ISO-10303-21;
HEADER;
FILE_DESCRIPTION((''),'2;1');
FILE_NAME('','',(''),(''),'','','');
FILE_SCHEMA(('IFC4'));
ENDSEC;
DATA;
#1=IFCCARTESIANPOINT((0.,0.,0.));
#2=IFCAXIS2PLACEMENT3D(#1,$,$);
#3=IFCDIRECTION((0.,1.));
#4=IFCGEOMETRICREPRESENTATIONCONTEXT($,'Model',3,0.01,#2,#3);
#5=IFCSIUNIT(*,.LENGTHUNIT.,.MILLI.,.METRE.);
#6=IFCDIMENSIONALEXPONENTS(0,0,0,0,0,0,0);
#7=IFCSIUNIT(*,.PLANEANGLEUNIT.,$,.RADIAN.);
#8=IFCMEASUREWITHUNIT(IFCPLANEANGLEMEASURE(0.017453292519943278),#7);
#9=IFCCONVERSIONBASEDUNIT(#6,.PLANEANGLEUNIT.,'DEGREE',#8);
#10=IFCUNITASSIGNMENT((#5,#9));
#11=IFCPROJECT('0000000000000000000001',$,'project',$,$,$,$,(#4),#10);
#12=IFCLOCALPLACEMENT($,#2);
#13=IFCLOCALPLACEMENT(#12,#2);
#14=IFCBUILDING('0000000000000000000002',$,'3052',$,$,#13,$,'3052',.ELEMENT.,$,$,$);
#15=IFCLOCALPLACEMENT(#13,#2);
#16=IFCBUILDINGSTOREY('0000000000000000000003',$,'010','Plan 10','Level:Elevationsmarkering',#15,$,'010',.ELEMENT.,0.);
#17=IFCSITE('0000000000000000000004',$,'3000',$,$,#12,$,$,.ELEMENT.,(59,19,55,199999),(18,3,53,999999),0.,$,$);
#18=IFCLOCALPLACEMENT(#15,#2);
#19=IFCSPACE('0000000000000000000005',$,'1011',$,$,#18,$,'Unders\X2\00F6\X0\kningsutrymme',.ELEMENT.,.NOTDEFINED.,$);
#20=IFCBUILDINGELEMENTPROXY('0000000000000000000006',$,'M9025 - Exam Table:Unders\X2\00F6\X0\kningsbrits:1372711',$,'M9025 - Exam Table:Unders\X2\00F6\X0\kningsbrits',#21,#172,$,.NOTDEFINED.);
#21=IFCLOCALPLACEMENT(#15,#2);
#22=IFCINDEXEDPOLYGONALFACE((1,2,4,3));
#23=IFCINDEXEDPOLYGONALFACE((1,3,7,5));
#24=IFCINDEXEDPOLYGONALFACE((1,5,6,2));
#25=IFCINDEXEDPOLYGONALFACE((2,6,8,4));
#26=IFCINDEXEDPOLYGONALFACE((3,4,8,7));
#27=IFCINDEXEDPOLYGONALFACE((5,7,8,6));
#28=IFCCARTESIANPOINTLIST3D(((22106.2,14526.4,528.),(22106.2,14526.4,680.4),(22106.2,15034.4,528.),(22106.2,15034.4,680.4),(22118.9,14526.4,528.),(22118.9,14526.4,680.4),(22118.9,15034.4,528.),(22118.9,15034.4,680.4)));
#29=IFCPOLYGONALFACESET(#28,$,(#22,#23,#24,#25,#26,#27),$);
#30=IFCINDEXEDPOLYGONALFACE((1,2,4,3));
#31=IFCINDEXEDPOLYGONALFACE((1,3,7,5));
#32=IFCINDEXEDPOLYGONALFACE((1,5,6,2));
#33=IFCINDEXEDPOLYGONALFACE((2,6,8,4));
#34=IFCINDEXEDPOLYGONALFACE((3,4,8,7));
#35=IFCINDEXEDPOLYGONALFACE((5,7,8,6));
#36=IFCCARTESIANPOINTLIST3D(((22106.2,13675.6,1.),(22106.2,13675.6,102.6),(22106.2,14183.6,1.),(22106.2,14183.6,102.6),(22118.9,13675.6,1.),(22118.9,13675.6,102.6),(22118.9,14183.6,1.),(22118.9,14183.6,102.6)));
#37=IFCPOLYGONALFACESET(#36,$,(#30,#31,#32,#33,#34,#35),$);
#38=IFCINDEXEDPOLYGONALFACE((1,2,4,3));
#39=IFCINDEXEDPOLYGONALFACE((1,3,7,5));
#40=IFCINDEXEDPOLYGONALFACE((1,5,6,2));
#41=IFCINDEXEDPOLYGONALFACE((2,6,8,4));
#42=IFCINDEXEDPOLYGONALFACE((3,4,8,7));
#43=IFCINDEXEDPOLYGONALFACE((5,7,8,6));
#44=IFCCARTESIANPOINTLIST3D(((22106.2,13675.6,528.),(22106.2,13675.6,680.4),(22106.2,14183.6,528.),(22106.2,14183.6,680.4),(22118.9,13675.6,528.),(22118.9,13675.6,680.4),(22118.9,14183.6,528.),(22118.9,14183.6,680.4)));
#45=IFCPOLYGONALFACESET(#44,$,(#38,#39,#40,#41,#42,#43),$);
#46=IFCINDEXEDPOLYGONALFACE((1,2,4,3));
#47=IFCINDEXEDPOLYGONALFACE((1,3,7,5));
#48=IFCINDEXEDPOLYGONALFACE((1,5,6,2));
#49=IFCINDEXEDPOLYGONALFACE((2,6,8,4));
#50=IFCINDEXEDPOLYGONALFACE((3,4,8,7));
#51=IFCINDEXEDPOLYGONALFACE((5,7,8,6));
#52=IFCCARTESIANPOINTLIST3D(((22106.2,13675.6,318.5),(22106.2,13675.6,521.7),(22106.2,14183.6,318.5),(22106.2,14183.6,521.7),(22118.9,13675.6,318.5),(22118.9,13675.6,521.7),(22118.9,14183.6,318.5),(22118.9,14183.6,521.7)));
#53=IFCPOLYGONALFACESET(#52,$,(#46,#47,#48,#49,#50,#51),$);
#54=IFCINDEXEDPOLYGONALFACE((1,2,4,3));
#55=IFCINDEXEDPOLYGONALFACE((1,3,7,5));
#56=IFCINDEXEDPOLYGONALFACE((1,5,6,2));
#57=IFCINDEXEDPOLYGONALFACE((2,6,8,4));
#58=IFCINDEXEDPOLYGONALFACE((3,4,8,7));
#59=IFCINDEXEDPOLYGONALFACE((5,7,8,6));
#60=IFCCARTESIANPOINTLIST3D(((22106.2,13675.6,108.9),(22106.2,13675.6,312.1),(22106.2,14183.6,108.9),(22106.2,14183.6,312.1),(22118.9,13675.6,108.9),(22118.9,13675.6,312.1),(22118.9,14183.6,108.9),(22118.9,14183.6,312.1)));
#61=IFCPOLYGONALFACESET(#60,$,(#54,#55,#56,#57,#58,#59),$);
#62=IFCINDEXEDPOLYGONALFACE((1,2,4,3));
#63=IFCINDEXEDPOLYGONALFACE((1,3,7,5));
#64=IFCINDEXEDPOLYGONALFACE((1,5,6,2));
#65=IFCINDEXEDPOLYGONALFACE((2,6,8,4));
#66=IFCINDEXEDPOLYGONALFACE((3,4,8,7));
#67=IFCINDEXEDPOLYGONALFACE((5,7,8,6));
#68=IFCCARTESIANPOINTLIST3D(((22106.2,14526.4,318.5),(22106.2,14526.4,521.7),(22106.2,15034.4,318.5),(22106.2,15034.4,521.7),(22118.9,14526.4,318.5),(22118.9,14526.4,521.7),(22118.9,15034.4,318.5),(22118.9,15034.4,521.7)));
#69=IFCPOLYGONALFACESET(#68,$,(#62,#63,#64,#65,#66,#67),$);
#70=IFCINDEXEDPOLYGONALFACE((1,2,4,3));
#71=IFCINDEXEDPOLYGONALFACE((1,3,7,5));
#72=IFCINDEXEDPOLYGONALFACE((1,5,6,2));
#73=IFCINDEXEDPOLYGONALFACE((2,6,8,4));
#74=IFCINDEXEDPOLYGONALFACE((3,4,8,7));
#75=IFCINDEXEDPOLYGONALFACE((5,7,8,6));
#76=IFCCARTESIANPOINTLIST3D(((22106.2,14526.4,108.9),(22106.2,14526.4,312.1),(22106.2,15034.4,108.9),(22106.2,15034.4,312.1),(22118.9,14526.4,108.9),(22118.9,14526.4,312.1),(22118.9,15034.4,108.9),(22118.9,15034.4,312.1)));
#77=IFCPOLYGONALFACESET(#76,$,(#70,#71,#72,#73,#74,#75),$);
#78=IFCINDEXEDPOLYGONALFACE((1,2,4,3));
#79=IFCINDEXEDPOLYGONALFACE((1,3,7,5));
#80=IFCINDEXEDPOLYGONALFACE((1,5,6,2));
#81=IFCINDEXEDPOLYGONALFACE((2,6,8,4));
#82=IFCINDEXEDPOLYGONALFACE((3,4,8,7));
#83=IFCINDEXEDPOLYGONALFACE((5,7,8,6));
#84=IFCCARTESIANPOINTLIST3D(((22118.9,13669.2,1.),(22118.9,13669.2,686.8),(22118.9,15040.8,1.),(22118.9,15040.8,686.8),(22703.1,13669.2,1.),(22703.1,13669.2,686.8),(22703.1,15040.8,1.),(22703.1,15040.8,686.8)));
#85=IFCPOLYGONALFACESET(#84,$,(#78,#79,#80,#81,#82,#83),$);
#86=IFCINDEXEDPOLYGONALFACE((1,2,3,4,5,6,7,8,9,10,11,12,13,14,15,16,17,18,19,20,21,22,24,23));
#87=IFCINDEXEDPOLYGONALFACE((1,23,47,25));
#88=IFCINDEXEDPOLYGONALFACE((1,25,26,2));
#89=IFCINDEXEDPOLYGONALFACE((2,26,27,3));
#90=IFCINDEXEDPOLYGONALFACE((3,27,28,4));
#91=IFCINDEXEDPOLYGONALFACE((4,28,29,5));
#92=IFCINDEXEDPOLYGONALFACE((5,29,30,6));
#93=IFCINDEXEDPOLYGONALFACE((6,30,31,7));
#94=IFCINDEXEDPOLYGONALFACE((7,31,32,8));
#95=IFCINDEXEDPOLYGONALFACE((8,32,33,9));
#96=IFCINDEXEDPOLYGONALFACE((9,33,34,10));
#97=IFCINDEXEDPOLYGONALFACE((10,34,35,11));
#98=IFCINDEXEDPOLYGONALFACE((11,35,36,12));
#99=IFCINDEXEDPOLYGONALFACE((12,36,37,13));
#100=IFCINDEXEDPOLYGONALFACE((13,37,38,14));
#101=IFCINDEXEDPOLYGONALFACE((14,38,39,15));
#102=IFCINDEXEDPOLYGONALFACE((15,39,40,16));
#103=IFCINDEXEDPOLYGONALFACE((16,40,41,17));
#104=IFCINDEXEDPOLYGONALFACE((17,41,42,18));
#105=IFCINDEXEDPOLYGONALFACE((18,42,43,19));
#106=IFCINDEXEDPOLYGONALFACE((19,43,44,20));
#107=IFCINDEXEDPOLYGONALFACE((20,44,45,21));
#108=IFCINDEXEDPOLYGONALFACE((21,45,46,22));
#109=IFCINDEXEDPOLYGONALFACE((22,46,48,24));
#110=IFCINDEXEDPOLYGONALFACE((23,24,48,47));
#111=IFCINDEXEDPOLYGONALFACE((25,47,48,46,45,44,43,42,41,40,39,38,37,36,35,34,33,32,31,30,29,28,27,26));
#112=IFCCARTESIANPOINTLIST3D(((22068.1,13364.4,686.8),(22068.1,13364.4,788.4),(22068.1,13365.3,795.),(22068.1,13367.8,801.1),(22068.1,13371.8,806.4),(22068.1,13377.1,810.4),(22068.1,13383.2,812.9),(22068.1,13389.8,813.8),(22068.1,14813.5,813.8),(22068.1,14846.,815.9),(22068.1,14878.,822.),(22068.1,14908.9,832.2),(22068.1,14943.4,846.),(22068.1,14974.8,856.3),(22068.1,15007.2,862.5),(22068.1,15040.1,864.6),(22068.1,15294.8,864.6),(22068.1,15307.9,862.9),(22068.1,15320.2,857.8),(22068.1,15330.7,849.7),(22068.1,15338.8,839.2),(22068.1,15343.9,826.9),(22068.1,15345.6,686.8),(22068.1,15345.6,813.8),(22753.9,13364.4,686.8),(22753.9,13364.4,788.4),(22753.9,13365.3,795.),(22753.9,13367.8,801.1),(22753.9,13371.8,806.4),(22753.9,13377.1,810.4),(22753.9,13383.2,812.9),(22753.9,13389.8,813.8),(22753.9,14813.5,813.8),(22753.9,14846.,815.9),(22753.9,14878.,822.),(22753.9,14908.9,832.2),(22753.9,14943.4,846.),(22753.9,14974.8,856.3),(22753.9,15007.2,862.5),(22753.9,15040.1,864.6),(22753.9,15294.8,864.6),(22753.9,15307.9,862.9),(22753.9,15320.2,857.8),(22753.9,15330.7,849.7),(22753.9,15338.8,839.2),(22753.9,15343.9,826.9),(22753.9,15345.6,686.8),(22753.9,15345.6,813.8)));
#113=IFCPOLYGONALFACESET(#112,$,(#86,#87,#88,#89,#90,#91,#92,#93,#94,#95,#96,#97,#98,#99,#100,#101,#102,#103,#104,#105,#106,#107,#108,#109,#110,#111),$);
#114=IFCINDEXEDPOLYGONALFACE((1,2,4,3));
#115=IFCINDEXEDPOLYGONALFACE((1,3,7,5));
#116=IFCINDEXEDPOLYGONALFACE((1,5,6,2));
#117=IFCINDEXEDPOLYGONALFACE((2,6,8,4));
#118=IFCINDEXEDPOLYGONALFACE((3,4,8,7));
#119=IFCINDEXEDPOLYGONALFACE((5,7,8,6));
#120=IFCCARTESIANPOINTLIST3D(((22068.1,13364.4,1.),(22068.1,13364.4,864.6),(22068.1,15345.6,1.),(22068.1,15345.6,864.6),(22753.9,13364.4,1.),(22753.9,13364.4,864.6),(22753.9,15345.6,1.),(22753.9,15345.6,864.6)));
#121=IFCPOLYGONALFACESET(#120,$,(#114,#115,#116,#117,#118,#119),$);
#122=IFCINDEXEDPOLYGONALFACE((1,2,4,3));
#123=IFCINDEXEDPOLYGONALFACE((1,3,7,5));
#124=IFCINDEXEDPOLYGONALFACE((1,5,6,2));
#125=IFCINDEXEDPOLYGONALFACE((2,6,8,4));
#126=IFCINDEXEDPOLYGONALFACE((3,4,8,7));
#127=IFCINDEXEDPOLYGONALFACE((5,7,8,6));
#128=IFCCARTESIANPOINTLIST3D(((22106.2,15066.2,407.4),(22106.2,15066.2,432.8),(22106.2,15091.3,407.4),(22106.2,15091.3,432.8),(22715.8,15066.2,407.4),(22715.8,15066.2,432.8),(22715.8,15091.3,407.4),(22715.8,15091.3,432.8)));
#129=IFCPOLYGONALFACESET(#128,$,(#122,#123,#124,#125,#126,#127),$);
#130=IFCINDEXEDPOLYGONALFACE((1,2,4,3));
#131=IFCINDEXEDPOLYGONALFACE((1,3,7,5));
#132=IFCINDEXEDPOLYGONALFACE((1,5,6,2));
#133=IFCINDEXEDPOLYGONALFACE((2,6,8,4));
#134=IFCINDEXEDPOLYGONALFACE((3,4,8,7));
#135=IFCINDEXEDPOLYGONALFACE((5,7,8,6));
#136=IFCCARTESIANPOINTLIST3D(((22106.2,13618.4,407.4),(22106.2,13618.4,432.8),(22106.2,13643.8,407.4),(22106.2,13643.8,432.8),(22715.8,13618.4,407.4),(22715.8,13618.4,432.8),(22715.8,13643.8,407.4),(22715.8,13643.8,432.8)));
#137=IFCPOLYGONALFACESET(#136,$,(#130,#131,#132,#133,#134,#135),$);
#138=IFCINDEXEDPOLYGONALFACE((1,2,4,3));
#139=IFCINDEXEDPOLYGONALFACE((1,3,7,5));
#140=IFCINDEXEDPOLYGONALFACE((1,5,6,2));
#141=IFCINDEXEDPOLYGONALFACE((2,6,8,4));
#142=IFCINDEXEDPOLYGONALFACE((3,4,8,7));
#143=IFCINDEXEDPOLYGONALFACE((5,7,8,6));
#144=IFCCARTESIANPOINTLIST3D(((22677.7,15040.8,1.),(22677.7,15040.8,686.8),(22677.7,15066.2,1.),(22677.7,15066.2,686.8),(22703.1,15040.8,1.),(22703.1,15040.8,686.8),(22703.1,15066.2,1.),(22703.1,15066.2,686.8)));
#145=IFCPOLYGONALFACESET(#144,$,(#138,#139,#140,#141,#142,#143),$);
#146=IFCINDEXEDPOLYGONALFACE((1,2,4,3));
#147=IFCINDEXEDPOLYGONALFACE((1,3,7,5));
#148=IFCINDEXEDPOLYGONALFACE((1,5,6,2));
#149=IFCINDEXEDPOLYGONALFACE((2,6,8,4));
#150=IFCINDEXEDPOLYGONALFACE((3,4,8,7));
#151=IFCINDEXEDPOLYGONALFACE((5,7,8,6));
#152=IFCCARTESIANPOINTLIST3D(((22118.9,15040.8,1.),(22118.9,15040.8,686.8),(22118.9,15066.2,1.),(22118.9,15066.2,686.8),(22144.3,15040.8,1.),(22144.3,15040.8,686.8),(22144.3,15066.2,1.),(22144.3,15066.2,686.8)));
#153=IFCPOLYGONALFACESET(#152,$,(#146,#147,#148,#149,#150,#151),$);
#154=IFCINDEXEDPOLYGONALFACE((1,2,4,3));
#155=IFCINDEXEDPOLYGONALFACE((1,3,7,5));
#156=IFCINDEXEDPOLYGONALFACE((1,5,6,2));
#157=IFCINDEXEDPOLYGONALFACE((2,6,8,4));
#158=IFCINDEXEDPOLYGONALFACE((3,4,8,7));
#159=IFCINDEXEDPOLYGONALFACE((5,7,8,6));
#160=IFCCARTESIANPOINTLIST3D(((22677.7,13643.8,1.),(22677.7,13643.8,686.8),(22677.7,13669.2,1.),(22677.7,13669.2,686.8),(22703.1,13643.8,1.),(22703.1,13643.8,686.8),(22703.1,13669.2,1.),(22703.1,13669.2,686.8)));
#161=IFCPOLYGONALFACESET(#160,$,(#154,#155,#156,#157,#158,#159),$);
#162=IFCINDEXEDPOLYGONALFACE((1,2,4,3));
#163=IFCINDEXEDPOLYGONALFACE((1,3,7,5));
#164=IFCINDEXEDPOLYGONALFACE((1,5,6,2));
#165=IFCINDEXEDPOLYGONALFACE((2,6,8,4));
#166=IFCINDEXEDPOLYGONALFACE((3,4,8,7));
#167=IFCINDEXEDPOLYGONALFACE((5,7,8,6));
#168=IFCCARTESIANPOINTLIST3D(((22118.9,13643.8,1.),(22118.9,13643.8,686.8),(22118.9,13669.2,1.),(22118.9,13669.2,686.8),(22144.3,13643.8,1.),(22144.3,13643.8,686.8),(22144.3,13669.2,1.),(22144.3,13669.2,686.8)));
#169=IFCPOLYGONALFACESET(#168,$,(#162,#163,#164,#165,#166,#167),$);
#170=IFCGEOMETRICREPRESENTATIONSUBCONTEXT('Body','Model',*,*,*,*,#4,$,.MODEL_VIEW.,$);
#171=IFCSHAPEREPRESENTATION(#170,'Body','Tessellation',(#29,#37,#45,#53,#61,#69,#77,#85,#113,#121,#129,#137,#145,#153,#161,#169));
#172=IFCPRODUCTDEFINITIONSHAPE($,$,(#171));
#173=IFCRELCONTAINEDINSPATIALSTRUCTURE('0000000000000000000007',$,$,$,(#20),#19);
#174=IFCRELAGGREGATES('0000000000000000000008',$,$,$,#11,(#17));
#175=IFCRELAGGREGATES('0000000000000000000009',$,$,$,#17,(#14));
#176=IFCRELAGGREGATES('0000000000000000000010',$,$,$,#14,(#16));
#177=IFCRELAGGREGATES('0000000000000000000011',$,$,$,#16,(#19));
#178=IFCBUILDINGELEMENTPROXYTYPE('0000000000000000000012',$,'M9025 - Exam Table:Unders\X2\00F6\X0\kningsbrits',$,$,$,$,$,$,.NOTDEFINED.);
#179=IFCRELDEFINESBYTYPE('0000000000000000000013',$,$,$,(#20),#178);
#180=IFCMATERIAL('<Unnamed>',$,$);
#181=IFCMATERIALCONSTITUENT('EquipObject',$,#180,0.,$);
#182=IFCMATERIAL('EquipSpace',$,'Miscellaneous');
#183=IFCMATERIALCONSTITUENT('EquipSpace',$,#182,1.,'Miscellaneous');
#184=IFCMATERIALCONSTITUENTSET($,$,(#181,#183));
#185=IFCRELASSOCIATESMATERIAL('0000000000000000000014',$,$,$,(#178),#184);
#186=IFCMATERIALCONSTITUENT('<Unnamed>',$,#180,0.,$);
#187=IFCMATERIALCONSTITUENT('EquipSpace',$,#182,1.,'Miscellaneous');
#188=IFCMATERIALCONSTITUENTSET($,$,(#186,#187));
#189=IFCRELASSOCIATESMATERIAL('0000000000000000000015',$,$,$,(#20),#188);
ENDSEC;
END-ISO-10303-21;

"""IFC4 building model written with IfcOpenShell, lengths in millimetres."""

from ifc_helpers import new_model, entity, si_unit, converted_unit, direction, frame, origin, place, context, subcontext, project, spatial, line, arc, indexed_curve, outline, extrude, source, transform, mapped, material, constituent, constituent_set, type_object, type_shapes, element, save


model = new_model("IFC4")

# Units and contexts
model_context = context("Model", 3, precision=0.01, world=origin(), true_north=direction((0.0, 1.0)))
body_context = subcontext(model_context, "Body", "Model", "MODEL_VIEW")
ifc_project = project(units=[si_unit("LENGTHUNIT", "METRE", prefix="MILLI"), converted_unit("PLANEANGLEUNIT", "DEGREE", entity("IfcPlaneAngleMeasure", 0.017453292519943278), si_unit("PLANEANGLEUNIT", "RADIAN"), dimensions=[0, 0, 0, 0, 0, 0, 0])], contexts=[model_context])

# Site, building, storey
site_placement = place(None, origin())
site = spatial("IfcSite", under=ifc_project, at=site_placement, Name="3000", CompositionType="ELEMENT", RefLatitude=(59, 19, 55, 199999), RefLongitude=(18, 3, 53, 999999), RefElevation=0.0)
building_placement = place(site_placement, origin())
building = spatial("IfcBuilding", under=site, at=building_placement, Name="3052", LongName="3052", CompositionType="ELEMENT")
storey_placement = place(building_placement, origin())
storey = spatial("IfcBuildingStorey", under=building, at=storey_placement, Name="010", Description="Plan 10", ObjectType="Level:Elevationsmarkering", LongName="010", CompositionType="ELEMENT", Elevation=0.0)

# Shared definitions
ifc_material_1 = material(Name="<Unnamed>")
ifc_material_2 = material(Name="EquipSpace", Category="Miscellaneous")
ifc_constituent_1 = constituent(ifc_material_1, Name="EquipObject", fraction=0.0)
ifc_constituent_2 = constituent(ifc_material_2, Name="EquipSpace", Category="Miscellaneous", fraction=1.0)
ifc_constituent_set_1 = constituent_set(constituents=[ifc_constituent_1, ifc_constituent_2])
building_element_proxy_type = type_object("IfcBuildingElementProxyType", Name="M9025 - Exam Table:Undersökningsbrits", PredefinedType="NOTDEFINED", material=ifc_constituent_set_1)
shared_shape_1 = source(origin(), body_context, "Body", "SweptSolid", [
    extrude(outline(indexed_curve([(-6.3, -254.0), (6.3, -254.0), (6.3, 254.0), (-6.3, 254.0), (-6.3, -254.0)], self_intersect=False)), frame((-298.4, 425.4, 527.0), z_axis=(0.0, 0.0, 1.0), x_axis=(-1.0, 0.0, 0.0)), (0.0, 0.0, 1.0), 152.4),
    extrude(outline(indexed_curve([(-6.3, -254.0), (6.3, -254.0), (6.3, 254.0), (-6.3, 254.0), (-6.3, -254.0)], self_intersect=False)), frame((-298.4, -425.4, 0.0), z_axis=(0.0, 0.0, 1.0), x_axis=(-1.0, 0.0, 0.0)), (0.0, 0.0, 1.0), 101.6),
    extrude(outline(indexed_curve([(-6.3, -254.0), (6.3, -254.0), (6.3, 254.0), (-6.3, 254.0), (-6.3, -254.0)], self_intersect=False)), frame((-298.4, -425.4, 527.0), z_axis=(0.0, 0.0, 1.0), x_axis=(-1.0, 0.0, 0.0)), (0.0, 0.0, 1.0), 152.4),
    extrude(outline(indexed_curve([(-6.3, -254.0), (6.3, -254.0), (6.3, 254.0), (-6.3, 254.0), (-6.3, -254.0)], self_intersect=False)), frame((-298.4, -425.4, 317.5), z_axis=(0.0, 0.0, 1.0), x_axis=(-1.0, 0.0, 0.0)), (0.0, 0.0, 1.0), 203.2),
    extrude(outline(indexed_curve([(-6.3, -254.0), (6.3, -254.0), (6.3, 254.0), (-6.3, 254.0), (-6.3, -254.0)], self_intersect=False)), frame((-298.4, -425.4, 107.9), z_axis=(0.0, 0.0, 1.0), x_axis=(-1.0, 0.0, 0.0)), (0.0, 0.0, 1.0), 203.2),
    extrude(outline(indexed_curve([(-6.3, -254.0), (6.3, -254.0), (6.3, 254.0), (-6.3, 254.0), (-6.3, -254.0)], self_intersect=False)), frame((-298.4, 425.4, 317.5), z_axis=(0.0, 0.0, 1.0), x_axis=(-1.0, 0.0, 0.0)), (0.0, 0.0, 1.0), 203.2),
    extrude(outline(indexed_curve([(-6.3, -254.0), (6.3, -254.0), (6.3, 254.0), (-6.3, 254.0), (-6.3, -254.0)], self_intersect=False)), frame((-298.4, 425.4, 107.9), z_axis=(0.0, 0.0, 1.0), x_axis=(-1.0, 0.0, 0.0)), (0.0, 0.0, 1.0), 203.2),
    extrude(outline(indexed_curve([(-292.1, -685.8), (292.1, -685.8), (292.1, 685.8), (-292.1, 685.8), (-292.1, -685.8)], self_intersect=False)), frame((0.0, 0.0, 0.0), z_axis=(0.0, 0.0, 1.0), x_axis=(-1.0, 0.0, 0.0)), (0.0, 0.0, 1.0), 685.8),
    extrude(outline(indexed_curve([(-114.3, -764.5), (12.7, -764.5), (48.6, -749.7), (63.5, -713.7), (63.5, -459.1), (58.8, -409.8), (44.9, -362.4), (31.1, -327.9), (17.4, -281.0), (12.7, -232.5), (12.7, 1191.3), (5.3, 1209.2), (-12.7, 1216.7), (-114.3, 1216.7)], segments=[line(1, 2), arc(2, 3, 4), line(4, 5), arc(5, 6, 7), line(7, 8), arc(8, 9, 10), line(10, 11), arc(11, 12, 13), line(13, 14, 1)], self_intersect=False)), frame((-342.9, 226.1, 800.1), z_axis=(1.0, 0.0, 0.0), x_axis=(0.0, 0.0, 1.0)), (0.0, 0.0, 1.0), 685.8),
    extrude(outline(indexed_curve([(-342.9, -990.6), (342.9, -990.6), (342.9, 990.6), (-342.9, 990.6), (-342.9, -990.6)], self_intersect=False)), frame((0.0, 0.0, 0.0), z_axis=(0.0, 0.0, 1.0), x_axis=(-1.0, 0.0, 0.0)), (0.0, 0.0, 1.0), 863.6),
    extrude(outline(indexed_curve([(-304.8, -12.5), (304.8, -12.5), (304.8, 12.5), (-304.8, 12.5), (-304.8, -12.5)], self_intersect=False)), frame((0.0, 723.7, 406.4), z_axis=(0.0, 0.0, 1.0), x_axis=(-1.0, 0.0, 0.0)), (0.0, 0.0, 1.0), 25.4),
    extrude(outline(indexed_curve([(-304.8, -12.7), (304.8, -12.7), (304.8, 12.7), (-304.8, 12.7), (-304.8, -12.7)], self_intersect=False)), frame((0.0, -723.9, 406.4), z_axis=(0.0, 0.0, 1.0), x_axis=(-1.0, 0.0, 0.0)), (0.0, 0.0, 1.0), 25.4),
    extrude(outline(indexed_curve([(-12.7, -12.7), (12.7, -12.7), (12.7, 12.7), (-12.7, 12.7), (-12.7, -12.7)], self_intersect=False)), frame((279.4, 698.5, 0.0), z_axis=(0.0, 0.0, 1.0), x_axis=(0.0, 1.0, 0.0)), (0.0, 0.0, 1.0), 685.8),
    extrude(outline(indexed_curve([(-12.7, -12.7), (12.7, -12.7), (12.7, 12.7), (-12.7, 12.7), (-12.7, -12.7)], self_intersect=False)), frame((-279.4, 698.5, 0.0)), (0.0, 0.0, 1.0), 685.8),
    extrude(outline(indexed_curve([(-12.7, -12.7), (12.7, -12.7), (12.7, 12.7), (-12.7, 12.7), (-12.7, -12.7)], self_intersect=False)), frame((279.4, -698.5, 0.0), z_axis=(0.0, 0.0, 1.0), x_axis=(-1.0, 0.0, 0.0)), (0.0, 0.0, 1.0), 685.8),
    extrude(outline(indexed_curve([(-12.7, -12.7), (12.7, -12.7), (12.7, 12.7), (-12.7, 12.7), (-12.7, -12.7)], self_intersect=False)), frame((-279.4, -698.5, 0.0), z_axis=(0.0, 0.0, 1.0), x_axis=(0.0, -1.0, 0.0)), (0.0, 0.0, 1.0), 685.8),
])
type_shapes(building_element_proxy_type, [shared_shape_1])

# Shared definitions
space_1_placement = place(storey_placement, origin())
space_1 = spatial("IfcSpace", under=storey, at=space_1_placement, Name="1011", LongName="Undersökningsutrymme", CompositionType="ELEMENT", PredefinedType="NOTDEFINED")

# Building element proxy
ifc_constituent_3 = constituent(ifc_material_1, Name="<Unnamed>", fraction=0.0)
ifc_constituent_4 = constituent(ifc_material_2, Name="EquipSpace", Category="Miscellaneous", fraction=1.0)
ifc_constituent_set_2 = constituent_set(constituents=[ifc_constituent_3, ifc_constituent_4])
proxy_1_placement = place(space_1_placement, frame((22411.0, 14355.0, 1.0)))
element("IfcBuildingElementProxy", 1, at=proxy_1_placement, inside=space_1, type_object=building_element_proxy_type, material=ifc_constituent_set_2, Name="M9025 - Exam Table:Undersökningsbrits:1372711", ObjectType="M9025 - Exam Table:Undersökningsbrits", PredefinedType="NOTDEFINED", context=body_context, shape_type="MappedRepresentation", body=[
    mapped(shared_shape_1, transform((0.0, 0.0, 0.0), scale=1.0)),
])

save(model, "model.ifc")
